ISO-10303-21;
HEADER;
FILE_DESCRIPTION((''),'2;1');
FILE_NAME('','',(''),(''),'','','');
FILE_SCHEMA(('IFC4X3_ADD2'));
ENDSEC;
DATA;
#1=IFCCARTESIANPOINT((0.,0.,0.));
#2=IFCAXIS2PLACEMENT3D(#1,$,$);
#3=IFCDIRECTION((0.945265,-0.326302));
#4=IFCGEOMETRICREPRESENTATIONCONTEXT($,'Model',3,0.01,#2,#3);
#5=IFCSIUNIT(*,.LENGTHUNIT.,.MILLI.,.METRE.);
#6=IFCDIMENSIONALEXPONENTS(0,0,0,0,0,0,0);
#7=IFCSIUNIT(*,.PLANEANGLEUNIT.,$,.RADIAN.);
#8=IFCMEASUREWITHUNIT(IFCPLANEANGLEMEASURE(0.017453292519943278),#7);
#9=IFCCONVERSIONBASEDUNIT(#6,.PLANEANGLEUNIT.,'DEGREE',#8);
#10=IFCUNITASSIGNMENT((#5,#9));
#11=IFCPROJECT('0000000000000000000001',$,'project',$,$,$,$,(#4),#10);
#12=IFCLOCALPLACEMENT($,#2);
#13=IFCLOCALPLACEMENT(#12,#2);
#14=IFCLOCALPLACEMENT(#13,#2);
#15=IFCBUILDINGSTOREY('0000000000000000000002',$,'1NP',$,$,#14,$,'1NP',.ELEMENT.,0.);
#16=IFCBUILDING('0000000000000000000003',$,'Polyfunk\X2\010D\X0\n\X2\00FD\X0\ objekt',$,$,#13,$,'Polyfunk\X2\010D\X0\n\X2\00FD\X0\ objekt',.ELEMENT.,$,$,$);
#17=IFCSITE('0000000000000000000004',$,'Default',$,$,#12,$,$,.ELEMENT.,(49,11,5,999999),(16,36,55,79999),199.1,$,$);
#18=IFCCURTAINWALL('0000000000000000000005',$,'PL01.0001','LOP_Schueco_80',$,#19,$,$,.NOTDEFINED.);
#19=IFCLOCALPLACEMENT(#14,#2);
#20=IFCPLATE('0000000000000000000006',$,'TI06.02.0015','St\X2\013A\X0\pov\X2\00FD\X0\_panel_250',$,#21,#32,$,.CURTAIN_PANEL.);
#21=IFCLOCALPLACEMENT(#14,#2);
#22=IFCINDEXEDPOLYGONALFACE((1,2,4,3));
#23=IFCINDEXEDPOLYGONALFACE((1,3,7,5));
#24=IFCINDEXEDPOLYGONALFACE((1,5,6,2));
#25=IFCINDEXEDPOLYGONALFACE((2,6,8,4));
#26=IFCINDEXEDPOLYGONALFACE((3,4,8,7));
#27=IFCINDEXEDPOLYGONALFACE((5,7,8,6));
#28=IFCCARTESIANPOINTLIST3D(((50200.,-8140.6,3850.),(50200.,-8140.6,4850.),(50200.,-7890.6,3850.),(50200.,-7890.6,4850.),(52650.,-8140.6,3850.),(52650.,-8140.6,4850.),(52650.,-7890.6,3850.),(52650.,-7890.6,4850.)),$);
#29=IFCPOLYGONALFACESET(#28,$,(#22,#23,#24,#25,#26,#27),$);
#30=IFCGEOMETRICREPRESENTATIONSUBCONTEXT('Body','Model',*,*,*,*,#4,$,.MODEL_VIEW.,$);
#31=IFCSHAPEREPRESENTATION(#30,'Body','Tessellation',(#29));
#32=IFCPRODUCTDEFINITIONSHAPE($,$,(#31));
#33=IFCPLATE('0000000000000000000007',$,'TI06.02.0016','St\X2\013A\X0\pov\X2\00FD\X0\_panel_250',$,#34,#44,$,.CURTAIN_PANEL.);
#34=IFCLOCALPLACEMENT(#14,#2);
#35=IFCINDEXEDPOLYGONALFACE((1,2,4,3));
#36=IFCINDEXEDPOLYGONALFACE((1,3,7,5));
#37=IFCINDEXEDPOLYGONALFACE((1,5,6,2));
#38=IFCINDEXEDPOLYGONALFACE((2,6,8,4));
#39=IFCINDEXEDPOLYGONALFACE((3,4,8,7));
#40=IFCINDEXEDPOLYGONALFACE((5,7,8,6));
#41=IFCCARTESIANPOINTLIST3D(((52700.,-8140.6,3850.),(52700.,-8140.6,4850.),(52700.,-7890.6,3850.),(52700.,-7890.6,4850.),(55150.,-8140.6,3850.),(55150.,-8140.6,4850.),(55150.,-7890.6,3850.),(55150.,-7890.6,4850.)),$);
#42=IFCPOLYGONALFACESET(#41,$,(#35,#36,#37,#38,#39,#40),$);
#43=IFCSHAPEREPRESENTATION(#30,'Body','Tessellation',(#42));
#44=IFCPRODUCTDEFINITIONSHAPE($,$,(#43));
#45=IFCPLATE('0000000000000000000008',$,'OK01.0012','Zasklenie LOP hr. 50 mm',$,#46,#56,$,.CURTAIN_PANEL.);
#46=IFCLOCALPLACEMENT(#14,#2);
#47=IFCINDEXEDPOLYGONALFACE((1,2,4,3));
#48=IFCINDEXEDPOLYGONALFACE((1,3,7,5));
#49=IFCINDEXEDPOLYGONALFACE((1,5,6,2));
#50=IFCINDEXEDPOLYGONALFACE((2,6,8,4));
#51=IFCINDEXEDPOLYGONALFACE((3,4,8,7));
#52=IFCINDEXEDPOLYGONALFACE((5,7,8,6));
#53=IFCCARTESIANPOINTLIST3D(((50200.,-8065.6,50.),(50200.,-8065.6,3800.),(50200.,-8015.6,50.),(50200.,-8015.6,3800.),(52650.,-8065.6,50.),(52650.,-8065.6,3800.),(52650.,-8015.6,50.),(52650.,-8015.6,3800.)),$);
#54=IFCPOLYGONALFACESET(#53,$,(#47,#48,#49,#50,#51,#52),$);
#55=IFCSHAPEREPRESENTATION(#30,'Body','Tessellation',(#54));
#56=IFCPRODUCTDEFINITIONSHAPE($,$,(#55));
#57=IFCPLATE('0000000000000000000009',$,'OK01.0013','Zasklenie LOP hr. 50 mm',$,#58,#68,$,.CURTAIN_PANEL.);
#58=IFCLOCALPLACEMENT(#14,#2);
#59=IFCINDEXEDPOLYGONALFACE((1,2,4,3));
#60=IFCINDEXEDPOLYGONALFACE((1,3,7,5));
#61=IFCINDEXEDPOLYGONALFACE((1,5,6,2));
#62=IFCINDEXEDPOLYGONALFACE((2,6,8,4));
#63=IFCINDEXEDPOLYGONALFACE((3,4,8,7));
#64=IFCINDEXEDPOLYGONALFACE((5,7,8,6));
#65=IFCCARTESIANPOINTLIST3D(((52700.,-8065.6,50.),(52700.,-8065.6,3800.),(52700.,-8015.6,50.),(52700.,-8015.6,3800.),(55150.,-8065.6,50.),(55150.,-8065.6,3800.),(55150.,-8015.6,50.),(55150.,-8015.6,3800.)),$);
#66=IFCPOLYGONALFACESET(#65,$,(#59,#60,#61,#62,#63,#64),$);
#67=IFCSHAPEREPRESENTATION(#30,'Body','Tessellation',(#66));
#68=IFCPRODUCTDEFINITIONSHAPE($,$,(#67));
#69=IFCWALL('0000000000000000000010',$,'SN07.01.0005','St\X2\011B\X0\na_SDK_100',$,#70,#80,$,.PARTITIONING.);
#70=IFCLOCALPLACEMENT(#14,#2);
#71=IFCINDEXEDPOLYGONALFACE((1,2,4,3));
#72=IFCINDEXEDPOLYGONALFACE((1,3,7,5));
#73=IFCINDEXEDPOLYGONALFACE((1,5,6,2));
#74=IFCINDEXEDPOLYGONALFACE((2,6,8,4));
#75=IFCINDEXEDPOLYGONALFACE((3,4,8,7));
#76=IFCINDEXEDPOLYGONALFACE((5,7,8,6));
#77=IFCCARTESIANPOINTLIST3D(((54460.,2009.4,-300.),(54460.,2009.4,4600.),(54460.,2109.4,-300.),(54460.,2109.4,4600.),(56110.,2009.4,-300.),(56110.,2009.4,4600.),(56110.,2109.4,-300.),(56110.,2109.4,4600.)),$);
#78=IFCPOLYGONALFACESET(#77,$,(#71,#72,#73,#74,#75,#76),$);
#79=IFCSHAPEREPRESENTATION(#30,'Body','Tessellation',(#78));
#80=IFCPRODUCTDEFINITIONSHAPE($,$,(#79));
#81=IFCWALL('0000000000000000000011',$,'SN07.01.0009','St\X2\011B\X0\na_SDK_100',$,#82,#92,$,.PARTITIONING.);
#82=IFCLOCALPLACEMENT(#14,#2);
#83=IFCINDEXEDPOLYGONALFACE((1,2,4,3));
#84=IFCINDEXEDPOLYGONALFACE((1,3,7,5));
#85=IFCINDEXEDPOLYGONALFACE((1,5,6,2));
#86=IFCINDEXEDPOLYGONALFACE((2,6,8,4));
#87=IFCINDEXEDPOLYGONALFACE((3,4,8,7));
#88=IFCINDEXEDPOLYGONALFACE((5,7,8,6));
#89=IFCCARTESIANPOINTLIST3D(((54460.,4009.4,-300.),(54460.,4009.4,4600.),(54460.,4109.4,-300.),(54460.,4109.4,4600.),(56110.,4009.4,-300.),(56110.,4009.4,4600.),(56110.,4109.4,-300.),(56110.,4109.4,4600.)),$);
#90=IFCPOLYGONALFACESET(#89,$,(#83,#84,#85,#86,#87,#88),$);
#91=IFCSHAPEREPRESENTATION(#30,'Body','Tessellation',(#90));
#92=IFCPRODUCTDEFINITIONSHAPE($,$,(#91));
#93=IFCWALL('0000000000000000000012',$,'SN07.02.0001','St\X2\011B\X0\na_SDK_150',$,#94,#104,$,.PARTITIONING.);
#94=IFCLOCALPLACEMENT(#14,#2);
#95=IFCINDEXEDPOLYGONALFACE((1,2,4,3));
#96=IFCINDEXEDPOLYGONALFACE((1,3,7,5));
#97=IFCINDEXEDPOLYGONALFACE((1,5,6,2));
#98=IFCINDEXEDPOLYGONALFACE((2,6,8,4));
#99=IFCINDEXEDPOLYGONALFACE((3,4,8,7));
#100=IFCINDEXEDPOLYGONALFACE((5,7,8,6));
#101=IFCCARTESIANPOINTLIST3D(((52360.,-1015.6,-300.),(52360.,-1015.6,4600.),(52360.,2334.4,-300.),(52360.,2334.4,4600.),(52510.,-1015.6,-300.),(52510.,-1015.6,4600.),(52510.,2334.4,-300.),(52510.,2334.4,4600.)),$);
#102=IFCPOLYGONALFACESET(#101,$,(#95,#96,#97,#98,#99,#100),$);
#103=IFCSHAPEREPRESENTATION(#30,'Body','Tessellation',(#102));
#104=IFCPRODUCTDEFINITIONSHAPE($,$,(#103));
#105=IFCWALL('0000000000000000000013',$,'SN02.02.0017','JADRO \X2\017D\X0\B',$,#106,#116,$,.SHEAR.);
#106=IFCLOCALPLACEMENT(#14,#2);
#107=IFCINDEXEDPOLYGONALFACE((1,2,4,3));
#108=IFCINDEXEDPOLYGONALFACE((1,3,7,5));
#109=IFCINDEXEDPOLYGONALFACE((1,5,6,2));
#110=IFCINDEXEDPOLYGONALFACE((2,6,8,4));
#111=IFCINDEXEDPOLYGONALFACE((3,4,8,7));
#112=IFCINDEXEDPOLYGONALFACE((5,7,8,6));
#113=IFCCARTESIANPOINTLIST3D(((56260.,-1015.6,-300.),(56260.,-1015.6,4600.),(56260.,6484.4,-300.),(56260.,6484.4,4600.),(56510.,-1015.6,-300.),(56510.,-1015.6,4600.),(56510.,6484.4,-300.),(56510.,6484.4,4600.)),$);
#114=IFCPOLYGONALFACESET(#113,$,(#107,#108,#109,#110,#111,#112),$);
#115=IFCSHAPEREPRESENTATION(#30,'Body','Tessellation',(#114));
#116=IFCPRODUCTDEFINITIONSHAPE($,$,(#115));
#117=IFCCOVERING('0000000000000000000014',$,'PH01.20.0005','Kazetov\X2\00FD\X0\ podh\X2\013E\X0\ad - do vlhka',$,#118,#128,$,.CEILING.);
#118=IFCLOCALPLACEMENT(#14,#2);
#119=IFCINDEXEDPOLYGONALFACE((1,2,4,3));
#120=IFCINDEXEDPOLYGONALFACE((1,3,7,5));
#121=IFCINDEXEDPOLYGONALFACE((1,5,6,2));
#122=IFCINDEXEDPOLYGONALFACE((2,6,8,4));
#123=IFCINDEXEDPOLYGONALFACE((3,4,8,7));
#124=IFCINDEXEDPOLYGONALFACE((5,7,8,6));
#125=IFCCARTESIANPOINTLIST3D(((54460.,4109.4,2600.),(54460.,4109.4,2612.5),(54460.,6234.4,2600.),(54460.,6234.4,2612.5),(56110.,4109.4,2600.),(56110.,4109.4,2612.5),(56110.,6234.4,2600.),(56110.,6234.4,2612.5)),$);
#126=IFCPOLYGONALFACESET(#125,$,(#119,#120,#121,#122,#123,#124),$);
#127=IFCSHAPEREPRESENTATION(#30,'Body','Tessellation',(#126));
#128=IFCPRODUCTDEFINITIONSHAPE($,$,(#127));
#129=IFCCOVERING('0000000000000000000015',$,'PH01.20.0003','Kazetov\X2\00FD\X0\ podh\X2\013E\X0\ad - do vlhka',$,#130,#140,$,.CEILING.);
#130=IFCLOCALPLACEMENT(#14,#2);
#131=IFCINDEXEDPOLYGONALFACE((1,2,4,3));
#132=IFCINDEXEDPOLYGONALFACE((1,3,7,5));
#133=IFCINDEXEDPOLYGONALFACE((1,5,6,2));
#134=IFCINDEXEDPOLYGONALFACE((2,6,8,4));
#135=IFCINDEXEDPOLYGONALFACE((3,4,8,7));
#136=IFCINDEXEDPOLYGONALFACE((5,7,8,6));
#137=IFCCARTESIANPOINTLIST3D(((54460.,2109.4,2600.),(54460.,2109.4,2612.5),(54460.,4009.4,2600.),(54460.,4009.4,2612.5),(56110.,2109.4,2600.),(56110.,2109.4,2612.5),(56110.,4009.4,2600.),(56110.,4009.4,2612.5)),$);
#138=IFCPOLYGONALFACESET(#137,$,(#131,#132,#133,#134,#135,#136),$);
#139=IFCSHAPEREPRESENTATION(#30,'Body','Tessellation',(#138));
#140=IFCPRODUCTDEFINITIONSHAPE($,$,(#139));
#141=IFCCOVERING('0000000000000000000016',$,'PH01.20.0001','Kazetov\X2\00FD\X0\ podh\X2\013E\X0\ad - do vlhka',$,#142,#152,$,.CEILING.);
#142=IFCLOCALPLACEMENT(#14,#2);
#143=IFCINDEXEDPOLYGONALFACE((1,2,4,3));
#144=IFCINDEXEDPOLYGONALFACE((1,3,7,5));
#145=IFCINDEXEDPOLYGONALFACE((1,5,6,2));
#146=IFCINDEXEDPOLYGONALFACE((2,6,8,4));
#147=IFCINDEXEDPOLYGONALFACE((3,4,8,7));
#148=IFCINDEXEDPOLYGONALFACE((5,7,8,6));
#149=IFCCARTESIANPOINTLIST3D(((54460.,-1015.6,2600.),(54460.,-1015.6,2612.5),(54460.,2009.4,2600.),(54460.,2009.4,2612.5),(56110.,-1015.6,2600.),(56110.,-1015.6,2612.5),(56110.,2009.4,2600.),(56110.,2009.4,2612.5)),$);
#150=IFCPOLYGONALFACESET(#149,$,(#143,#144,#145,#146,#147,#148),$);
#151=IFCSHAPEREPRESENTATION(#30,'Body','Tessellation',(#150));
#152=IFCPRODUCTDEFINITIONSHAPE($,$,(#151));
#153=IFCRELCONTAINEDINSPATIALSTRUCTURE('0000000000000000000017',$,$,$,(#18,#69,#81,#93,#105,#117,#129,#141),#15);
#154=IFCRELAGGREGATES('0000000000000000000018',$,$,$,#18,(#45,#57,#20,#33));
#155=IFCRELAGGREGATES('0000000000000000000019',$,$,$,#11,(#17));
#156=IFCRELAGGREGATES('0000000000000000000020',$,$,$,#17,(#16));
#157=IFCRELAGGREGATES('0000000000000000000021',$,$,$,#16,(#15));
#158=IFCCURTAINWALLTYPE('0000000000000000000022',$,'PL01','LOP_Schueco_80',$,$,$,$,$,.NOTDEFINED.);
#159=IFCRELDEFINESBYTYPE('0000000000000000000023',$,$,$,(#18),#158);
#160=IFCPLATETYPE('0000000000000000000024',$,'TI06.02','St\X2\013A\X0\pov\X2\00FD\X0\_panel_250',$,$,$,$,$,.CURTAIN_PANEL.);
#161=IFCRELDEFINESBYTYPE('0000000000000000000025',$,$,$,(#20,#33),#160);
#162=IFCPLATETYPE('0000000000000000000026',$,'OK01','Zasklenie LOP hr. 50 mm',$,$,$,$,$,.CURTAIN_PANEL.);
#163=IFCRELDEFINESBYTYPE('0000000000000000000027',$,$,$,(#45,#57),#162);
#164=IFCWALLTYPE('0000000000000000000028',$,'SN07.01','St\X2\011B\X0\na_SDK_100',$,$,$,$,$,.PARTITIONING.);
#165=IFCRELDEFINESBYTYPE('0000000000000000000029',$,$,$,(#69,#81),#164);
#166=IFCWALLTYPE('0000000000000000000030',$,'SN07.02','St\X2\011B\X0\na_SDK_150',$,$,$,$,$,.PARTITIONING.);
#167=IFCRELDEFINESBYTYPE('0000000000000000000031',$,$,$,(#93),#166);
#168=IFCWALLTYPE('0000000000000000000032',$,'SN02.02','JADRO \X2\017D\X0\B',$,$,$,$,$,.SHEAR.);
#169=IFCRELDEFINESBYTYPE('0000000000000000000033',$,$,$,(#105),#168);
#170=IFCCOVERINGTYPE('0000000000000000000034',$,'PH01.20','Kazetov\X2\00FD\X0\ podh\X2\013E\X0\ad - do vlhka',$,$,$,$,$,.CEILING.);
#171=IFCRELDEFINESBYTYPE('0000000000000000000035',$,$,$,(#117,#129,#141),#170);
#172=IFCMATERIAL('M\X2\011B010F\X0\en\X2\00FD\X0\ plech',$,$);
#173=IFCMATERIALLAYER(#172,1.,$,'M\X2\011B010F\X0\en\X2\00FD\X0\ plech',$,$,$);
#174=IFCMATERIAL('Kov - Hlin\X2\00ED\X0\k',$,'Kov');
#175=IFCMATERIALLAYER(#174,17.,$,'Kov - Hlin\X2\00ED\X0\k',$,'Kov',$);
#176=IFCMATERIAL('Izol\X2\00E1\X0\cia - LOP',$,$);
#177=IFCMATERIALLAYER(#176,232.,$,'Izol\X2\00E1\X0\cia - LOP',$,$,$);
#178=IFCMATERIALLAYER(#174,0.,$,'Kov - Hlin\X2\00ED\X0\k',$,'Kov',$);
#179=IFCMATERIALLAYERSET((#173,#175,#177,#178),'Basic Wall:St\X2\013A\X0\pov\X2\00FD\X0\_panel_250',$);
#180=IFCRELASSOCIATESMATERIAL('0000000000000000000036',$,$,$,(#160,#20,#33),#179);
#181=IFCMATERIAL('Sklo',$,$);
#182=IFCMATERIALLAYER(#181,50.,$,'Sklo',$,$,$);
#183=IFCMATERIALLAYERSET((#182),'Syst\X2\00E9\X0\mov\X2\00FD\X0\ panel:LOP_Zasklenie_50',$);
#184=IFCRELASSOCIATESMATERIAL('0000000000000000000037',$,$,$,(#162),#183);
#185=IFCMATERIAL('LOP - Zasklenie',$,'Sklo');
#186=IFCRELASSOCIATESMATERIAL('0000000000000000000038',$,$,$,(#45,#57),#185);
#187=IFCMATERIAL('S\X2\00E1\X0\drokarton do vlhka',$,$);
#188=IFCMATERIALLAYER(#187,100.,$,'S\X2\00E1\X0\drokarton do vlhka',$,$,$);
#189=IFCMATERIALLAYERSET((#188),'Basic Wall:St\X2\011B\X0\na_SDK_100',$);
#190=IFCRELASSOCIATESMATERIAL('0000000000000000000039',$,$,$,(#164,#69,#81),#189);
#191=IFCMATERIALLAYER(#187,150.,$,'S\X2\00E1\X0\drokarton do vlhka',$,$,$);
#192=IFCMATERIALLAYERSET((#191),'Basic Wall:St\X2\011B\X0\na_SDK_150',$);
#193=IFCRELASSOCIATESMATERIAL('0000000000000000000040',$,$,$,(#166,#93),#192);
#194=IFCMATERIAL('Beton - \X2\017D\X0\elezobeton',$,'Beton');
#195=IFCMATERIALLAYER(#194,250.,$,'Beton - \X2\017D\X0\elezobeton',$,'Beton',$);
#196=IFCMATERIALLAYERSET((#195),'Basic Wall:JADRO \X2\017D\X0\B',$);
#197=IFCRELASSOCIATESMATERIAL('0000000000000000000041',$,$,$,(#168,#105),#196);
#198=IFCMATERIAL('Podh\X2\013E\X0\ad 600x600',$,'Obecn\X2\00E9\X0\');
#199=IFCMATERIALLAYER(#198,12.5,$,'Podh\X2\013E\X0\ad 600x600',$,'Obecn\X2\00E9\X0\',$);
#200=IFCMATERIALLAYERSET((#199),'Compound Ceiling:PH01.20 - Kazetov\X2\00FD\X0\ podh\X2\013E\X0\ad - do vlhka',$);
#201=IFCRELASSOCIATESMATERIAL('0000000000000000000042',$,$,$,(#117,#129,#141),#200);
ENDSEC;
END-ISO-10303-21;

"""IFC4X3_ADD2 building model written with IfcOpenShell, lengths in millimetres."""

from ifc_helpers import new_model, entity, si_unit, converted_unit, direction, frame, frame_2d, origin, origin_2d_with_axis, place, context, subcontext, project, spatial, polyline, rectangle, extrude, clip, bounded_halfspace, source, transform, mapped, material, layer, layer_set, layer_usage, type_object, type_shapes, element, aggregate, save


model = new_model("IFC4X3_ADD2")

# Units and contexts
model_context = context("Model", 3, precision=0.01, world=origin(), true_north=direction((0.945265, -0.326302)))
body_context = subcontext(model_context, "Body", "Model", "MODEL_VIEW")
ifc_project = project(units=[si_unit("LENGTHUNIT", "METRE", prefix="MILLI"), converted_unit("PLANEANGLEUNIT", "DEGREE", entity("IfcPlaneAngleMeasure", 0.017453292519943278), si_unit("PLANEANGLEUNIT", "RADIAN"), dimensions=[0, 0, 0, 0, 0, 0, 0])], contexts=[model_context])

# Site, building, storey
site_placement = place(None, origin())
site = spatial("IfcSite", under=ifc_project, at=site_placement, Name="Default", CompositionType="ELEMENT", RefLatitude=(49, 11, 5, 999999), RefLongitude=(16, 36, 55, 79999), RefElevation=199.1)
building_placement = place(site_placement, origin())
building = spatial("IfcBuilding", under=site, at=building_placement, Name="Polyfunkčný objekt", LongName="Polyfunkčný objekt", CompositionType="ELEMENT")
storey_placement = place(building_placement, origin())
storey = spatial("IfcBuildingStorey", under=building, at=storey_placement, Name="1NP", LongName="1NP", CompositionType="ELEMENT", Elevation=0.0)

# Curtain wall, plates
curtain_wall_type = type_object("IfcCurtainWallType", Name="PL01", Description="LOP_Schueco_80", PredefinedType="NOTDEFINED")
curtain_wall_placement = place(storey_placement, origin())
curtain_wall = element("IfcCurtainWall", 1, at=curtain_wall_placement, inside=storey, type_object=curtain_wall_type, Name="PL01.0001", Description="LOP_Schueco_80", PredefinedType="NOTDEFINED")
ifc_material_1 = material(Name="Měďený plech")
ifc_layer_1 = layer(ifc_material_1, 1.0, Name="Měďený plech")
ifc_material_2 = material(Name="Kov - Hliník", Category="Kov")
ifc_layer_2 = layer(ifc_material_2, 17.0, Name="Kov - Hliník", Category="Kov")
ifc_material_3 = material(Name="Izolácia - LOP")
ifc_layer_3 = layer(ifc_material_3, 232.0, Name="Izolácia - LOP")
ifc_layer_4 = layer(ifc_material_2, 0.0, Name="Kov - Hliník", Category="Kov")
ifc_layer_set_1 = layer_set([ifc_layer_1, ifc_layer_2, ifc_layer_3, ifc_layer_4], Name="Basic Wall:Stĺpový_panel_250")
ifc_layer_usage_1 = layer_usage(ifc_layer_set_1, "AXIS2", "POSITIVE", -125.0)
plate_type_1 = type_object("IfcPlateType", Name="TI06.02", Description="Stĺpový_panel_250", PredefinedType="CURTAIN_PANEL", material=ifc_layer_set_1)
plate_1_placement = place(storey_placement, frame((50200.0, -8015.6, 3850.0)))
plate_1 = element("IfcPlate", 2, at=plate_1_placement, type_object=plate_type_1, material=ifc_layer_usage_1, Name="TI06.02.0015", Description="Stĺpový_panel_250", PredefinedType="CURTAIN_PANEL", context=body_context, shape_type="SweptSolid", body=[
    extrude(rectangle(XDim=250.0, YDim=2450.0, at=origin_2d_with_axis()), frame((1225.0, 0.0, 0.0), z_axis=(0.0, 0.0, 1.0), x_axis=(0.0, 1.0, 0.0)), (0.0, 0.0, 1.0), 1000.0),
])
ifc_layer_usage_2 = layer_usage(ifc_layer_set_1, "AXIS2", "POSITIVE", -125.0)
plate_2_placement = place(storey_placement, frame((52700.0, -8015.6, 3850.0)))
plate_2 = element("IfcPlate", 3, at=plate_2_placement, type_object=plate_type_1, material=ifc_layer_usage_2, Name="TI06.02.0016", Description="Stĺpový_panel_250", PredefinedType="CURTAIN_PANEL", context=body_context, shape_type="SweptSolid", body=[
    extrude(rectangle(XDim=250.0, YDim=2450.0, at=frame_2d((0.0, 0.0), x_axis=(1.0, 0.0))), frame((1225.0, 0.0, 0.0), z_axis=(0.0, 0.0, 1.0), x_axis=(0.0, 1.0, 0.0)), (0.0, 0.0, 1.0), 1000.0),
])
ifc_material_4 = material(Name="LOP - Zasklenie", Category="Sklo")
ifc_material_5 = material(Name="Sklo")
ifc_layer_5 = layer(ifc_material_5, 50.0, Name="Sklo")
ifc_layer_set_2 = layer_set([ifc_layer_5], Name="Systémový panel:LOP_Zasklenie_50")
plate_type_2 = type_object("IfcPlateType", Name="OK01", Description="Zasklenie LOP hr. 50 mm", PredefinedType="CURTAIN_PANEL", material=ifc_layer_set_2)
shared_shape_1 = source(origin(), body_context, "Body", "SweptSolid", [
    extrude(rectangle(XDim=3750.0, YDim=2450.0, at=frame_2d((-331.2, 0.0), x_axis=(1.0, 0.0))), frame((0.0, -50.0, 2206.2), z_axis=(0.0, 1.0, 0.0), x_axis=(0.0, 0.0, 1.0)), (0.0, 0.0, 1.0), 50.0),
])
type_shapes(plate_type_2, [shared_shape_1])
plate_3_placement = place(curtain_wall_placement, frame((51425.0, -8015.6, 50.0)))
plate_3 = element("IfcPlate", 4, at=plate_3_placement, type_object=plate_type_2, material=ifc_material_4, Name="OK01.0012", Description="Zasklenie LOP hr. 50 mm", PredefinedType="CURTAIN_PANEL", context=body_context, shape_type="MappedRepresentation", body=[
    mapped(shared_shape_1, transform((0.0, 0.0, 0.0), scale=1.0)),
])
plate_4_placement = place(curtain_wall_placement, frame((53925.0, -8015.6, 50.0)))
plate_4 = element("IfcPlate", 5, at=plate_4_placement, type_object=plate_type_2, material=ifc_material_4, Name="OK01.0013", Description="Zasklenie LOP hr. 50 mm", PredefinedType="CURTAIN_PANEL", context=body_context, shape_type="MappedRepresentation", body=[
    mapped(shared_shape_1, transform((0.0, 0.0, 0.0), scale=1.0)),
])
aggregate(curtain_wall, [plate_3, plate_4, plate_1, plate_2])

# Walls
ifc_material_6 = material(Name="Sádrokarton do vlhka")
ifc_layer_6 = layer(ifc_material_6, 100.0, Name="Sádrokarton do vlhka")
ifc_layer_set_3 = layer_set([ifc_layer_6], Name="Basic Wall:Stěna_SDK_100")
wall_type_1 = type_object("IfcWallType", Name="SN07.01", Description="Stěna_SDK_100", PredefinedType="PARTITIONING", material=ifc_layer_set_3)
wall_1_placement = place(storey_placement, frame((54460.0, 2059.4, -300.0)))
element("IfcWall", 6, at=wall_1_placement, inside=storey, type_object=wall_type_1, material=ifc_layer_set_3, Name="SN07.01.0005", Description="Stěna_SDK_100", PredefinedType="PARTITIONING", context=body_context, shape_type="Clipping", body=[
    clip(clip(extrude(rectangle(XDim=1650.0, YDim=100.0, at=frame_2d((825.0, 0.0), x_axis=(-1.0, 0.0))), origin(), (0.0, 0.0, 1.0), 4900.0), bounded_halfspace(frame((0.0, -50.0, 4900.0), z_axis=(0.0, 0.0, -1.0), x_axis=(1.0, 0.0, 0.0)), True, frame((0.0, -50.0, 4900.0)), polyline([(0.0, 0.0), (1650.0, 0.0), (1650.0, 100.0), (0.0, 100.0), (0.0, 0.0)]))), bounded_halfspace(frame((1650.0, -50.0, 0.0), z_axis=(0.0, 0.0, 1.0), x_axis=(0.0, 1.0, 0.0)), True, frame((1650.0, -50.0, 0.0)), polyline([(0.0, 0.0), (0.0, 100.0), (-1650.0, 100.0), (-1650.0, 0.0), (0.0, 0.0)]))),
])
wall_2_placement = place(storey_placement, frame((54460.0, 4059.4, -300.0)))
element("IfcWall", 7, at=wall_2_placement, inside=storey, type_object=wall_type_1, material=ifc_layer_set_3, Name="SN07.01.0009", Description="Stěna_SDK_100", PredefinedType="PARTITIONING", context=body_context, shape_type="Clipping", body=[
    clip(clip(extrude(rectangle(XDim=1650.0, YDim=100.0, at=frame_2d((825.0, 0.0), x_axis=(-1.0, 0.0))), origin(), (0.0, 0.0, 1.0), 4900.0), bounded_halfspace(frame((0.0, -50.0, 4900.0), z_axis=(0.0, 0.0, -1.0), x_axis=(1.0, 0.0, 0.0)), True, frame((0.0, -50.0, 4900.0)), polyline([(0.0, 0.0), (1650.0, 0.0), (1650.0, 100.0), (0.0, 100.0), (0.0, 0.0)]))), bounded_halfspace(frame((1650.0, -50.0, 0.0), z_axis=(0.0, 0.0, 1.0), x_axis=(0.0, 1.0, 0.0)), True, frame((1650.0, -50.0, 0.0)), polyline([(0.0, 0.0), (0.0, 100.0), (-1650.0, 100.0), (-1650.0, 0.0), (0.0, 0.0)]))),
])
ifc_layer_7 = layer(ifc_material_6, 150.0, Name="Sádrokarton do vlhka")
ifc_layer_set_4 = layer_set([ifc_layer_7], Name="Basic Wall:Stěna_SDK_150")
wall_type_2 = type_object("IfcWallType", Name="SN07.02", Description="Stěna_SDK_150", PredefinedType="PARTITIONING", material=ifc_layer_set_4)
wall_3_placement = place(storey_placement, frame((52435.0, 2334.4, -300.0), z_axis=(0.0, 0.0, 1.0), x_axis=(0.0, -1.0, 0.0)))
element("IfcWall", 8, at=wall_3_placement, inside=storey, type_object=wall_type_2, material=ifc_layer_set_4, Name="SN07.02.0001", Description="Stěna_SDK_150", PredefinedType="PARTITIONING", context=body_context, shape_type="Clipping", body=[
    clip(clip(extrude(rectangle(XDim=3350.0, YDim=150.0, at=frame_2d((1675.0, 0.0), x_axis=(-1.0, 0.0))), origin(), (0.0, 0.0, 1.0), 4900.0), bounded_halfspace(frame((3350.0, -75.0, 0.0), z_axis=(0.0, 0.0, 1.0), x_axis=(-1.0, 0.0, 0.0)), True, frame((3350.0, -75.0, 0.0)), polyline([(0.0, 0.0), (0.0, 150.0), (-3350.0, 150.0), (-3350.0, 0.0), (0.0, 0.0)]))), bounded_halfspace(frame((0.0, -75.0, 4900.0), z_axis=(0.0, 0.0, -1.0), x_axis=(0.0, 1.0, 0.0)), True, frame((0.0, -75.0, 4900.0)), polyline([(0.0, 0.0), (3350.0, 0.0), (3350.0, 150.0), (0.0, 150.0), (0.0, 0.0)]))),
])
ifc_material_7 = material(Name="Beton - Železobeton", Category="Beton")
ifc_layer_8 = layer(ifc_material_7, 250.0, Name="Beton - Železobeton", Category="Beton")
ifc_layer_set_5 = layer_set([ifc_layer_8], Name="Basic Wall:JADRO ŽB")
wall_type_3 = type_object("IfcWallType", Name="SN02.02", Description="JADRO ŽB", PredefinedType="SHEAR", material=ifc_layer_set_5)
wall_4_placement = place(storey_placement, frame((56385.0, -1015.6, -300.0), z_axis=(0.0, 0.0, 1.0), x_axis=(0.0, 1.0, 0.0)))
element("IfcWall", 9, at=wall_4_placement, inside=storey, type_object=wall_type_3, material=ifc_layer_set_5, Name="SN02.02.0017", Description="JADRO ŽB", PredefinedType="SHEAR", context=body_context, shape_type="Clipping", body=[
    clip(clip(extrude(rectangle(XDim=7500.0, YDim=250.0, at=frame_2d((3750.0, 0.0), x_axis=(-1.0, 0.0))), origin(), (0.0, 0.0, 1.0), 4900.0), bounded_halfspace(frame((0.0, -125.0, 4900.0), z_axis=(0.0, 0.0, -1.0), x_axis=(0.0, -1.0, 0.0)), True, frame((0.0, -125.0, 4900.0)), polyline([(0.0, 0.0), (7500.0, 0.0), (7500.0, 250.0), (7250.0, 250.0), (0.0, 250.0), (0.0, 0.0)]))), bounded_halfspace(frame((0.0, -125.0, 0.0)), True, frame((0.0, -125.0, 0.0)), polyline([(0.0, 0.0), (7110.0, 0.0), (7500.0, 0.0), (7500.0, 250.0), (7250.0, 250.0), (0.0, 250.0), (0.0, 0.0)]))),
])

# Shared definitions
ifc_material_8 = material(Name="Podhľad 600x600", Category="Obecné")

# Coverings
ifc_layer_9 = layer(ifc_material_8, 12.5, Name="Podhľad 600x600", Category="Obecné")
ifc_layer_set_6 = layer_set([ifc_layer_9], Name="Compound Ceiling:PH01.20 - Kazetový podhľad - do vlhka")
ifc_layer_usage_3 = layer_usage(ifc_layer_set_6, "AXIS3", "NEGATIVE", 0.0)
covering_type_1 = type_object("IfcCoveringType", Name="PH01.20", Description="Kazetový podhľad - do vlhka", PredefinedType="CEILING")
covering_1_placement = place(storey_placement, frame((54460.0, 4109.4, 2600.0)))
element("IfcCovering", 10, at=covering_1_placement, inside=storey, type_object=covering_type_1, material=ifc_layer_usage_3, Name="PH01.20.0005", Description="Kazetový podhľad - do vlhka", PredefinedType="CEILING", context=body_context, shape_type="SweptSolid", body=[
    extrude(rectangle(XDim=2125.0, YDim=1650.0, at=frame_2d((0.0, 0.0), x_axis=(1.0, 0.0))), frame((825.0, 1062.5, 0.0), z_axis=(0.0, 0.0, 1.0), x_axis=(0.0, -1.0, 0.0)), (0.0, 0.0, 1.0), 12.5),
])
ifc_layer_usage_4 = layer_usage(ifc_layer_set_6, "AXIS3", "NEGATIVE", 0.0)
covering_2_placement = place(storey_placement, frame((54460.0, 2109.4, 2600.0)))
element("IfcCovering", 11, at=covering_2_placement, inside=storey, type_object=covering_type_1, material=ifc_layer_usage_4, Name="PH01.20.0003", Description="Kazetový podhľad - do vlhka", PredefinedType="CEILING", context=body_context, shape_type="SweptSolid", body=[
    extrude(rectangle(XDim=1900.0, YDim=1650.0, at=frame_2d((0.0, 0.0), x_axis=(1.0, 0.0))), frame((825.0, 950.0, 0.0), z_axis=(0.0, 0.0, 1.0), x_axis=(0.0, 1.0, 0.0)), (0.0, 0.0, 1.0), 12.5),
])
ifc_layer_usage_5 = layer_usage(ifc_layer_set_6, "AXIS3", "NEGATIVE", 0.0)
covering_3_placement = place(storey_placement, frame((54460.0, -1015.6, 2600.0)))
element("IfcCovering", 12, at=covering_3_placement, inside=storey, type_object=covering_type_1, material=ifc_layer_usage_5, Name="PH01.20.0001", Description="Kazetový podhľad - do vlhka", PredefinedType="CEILING", context=body_context, shape_type="SweptSolid", body=[
    extrude(rectangle(XDim=1650.0, YDim=3025.0, at=frame_2d((0.0, 0.0), x_axis=(1.0, 0.0))), frame((825.0, 1512.5, 0.0), z_axis=(0.0, 0.0, 1.0), x_axis=(-1.0, 0.0, 0.0)), (0.0, 0.0, 1.0), 12.5),
])

save(model, "model.ifc")
